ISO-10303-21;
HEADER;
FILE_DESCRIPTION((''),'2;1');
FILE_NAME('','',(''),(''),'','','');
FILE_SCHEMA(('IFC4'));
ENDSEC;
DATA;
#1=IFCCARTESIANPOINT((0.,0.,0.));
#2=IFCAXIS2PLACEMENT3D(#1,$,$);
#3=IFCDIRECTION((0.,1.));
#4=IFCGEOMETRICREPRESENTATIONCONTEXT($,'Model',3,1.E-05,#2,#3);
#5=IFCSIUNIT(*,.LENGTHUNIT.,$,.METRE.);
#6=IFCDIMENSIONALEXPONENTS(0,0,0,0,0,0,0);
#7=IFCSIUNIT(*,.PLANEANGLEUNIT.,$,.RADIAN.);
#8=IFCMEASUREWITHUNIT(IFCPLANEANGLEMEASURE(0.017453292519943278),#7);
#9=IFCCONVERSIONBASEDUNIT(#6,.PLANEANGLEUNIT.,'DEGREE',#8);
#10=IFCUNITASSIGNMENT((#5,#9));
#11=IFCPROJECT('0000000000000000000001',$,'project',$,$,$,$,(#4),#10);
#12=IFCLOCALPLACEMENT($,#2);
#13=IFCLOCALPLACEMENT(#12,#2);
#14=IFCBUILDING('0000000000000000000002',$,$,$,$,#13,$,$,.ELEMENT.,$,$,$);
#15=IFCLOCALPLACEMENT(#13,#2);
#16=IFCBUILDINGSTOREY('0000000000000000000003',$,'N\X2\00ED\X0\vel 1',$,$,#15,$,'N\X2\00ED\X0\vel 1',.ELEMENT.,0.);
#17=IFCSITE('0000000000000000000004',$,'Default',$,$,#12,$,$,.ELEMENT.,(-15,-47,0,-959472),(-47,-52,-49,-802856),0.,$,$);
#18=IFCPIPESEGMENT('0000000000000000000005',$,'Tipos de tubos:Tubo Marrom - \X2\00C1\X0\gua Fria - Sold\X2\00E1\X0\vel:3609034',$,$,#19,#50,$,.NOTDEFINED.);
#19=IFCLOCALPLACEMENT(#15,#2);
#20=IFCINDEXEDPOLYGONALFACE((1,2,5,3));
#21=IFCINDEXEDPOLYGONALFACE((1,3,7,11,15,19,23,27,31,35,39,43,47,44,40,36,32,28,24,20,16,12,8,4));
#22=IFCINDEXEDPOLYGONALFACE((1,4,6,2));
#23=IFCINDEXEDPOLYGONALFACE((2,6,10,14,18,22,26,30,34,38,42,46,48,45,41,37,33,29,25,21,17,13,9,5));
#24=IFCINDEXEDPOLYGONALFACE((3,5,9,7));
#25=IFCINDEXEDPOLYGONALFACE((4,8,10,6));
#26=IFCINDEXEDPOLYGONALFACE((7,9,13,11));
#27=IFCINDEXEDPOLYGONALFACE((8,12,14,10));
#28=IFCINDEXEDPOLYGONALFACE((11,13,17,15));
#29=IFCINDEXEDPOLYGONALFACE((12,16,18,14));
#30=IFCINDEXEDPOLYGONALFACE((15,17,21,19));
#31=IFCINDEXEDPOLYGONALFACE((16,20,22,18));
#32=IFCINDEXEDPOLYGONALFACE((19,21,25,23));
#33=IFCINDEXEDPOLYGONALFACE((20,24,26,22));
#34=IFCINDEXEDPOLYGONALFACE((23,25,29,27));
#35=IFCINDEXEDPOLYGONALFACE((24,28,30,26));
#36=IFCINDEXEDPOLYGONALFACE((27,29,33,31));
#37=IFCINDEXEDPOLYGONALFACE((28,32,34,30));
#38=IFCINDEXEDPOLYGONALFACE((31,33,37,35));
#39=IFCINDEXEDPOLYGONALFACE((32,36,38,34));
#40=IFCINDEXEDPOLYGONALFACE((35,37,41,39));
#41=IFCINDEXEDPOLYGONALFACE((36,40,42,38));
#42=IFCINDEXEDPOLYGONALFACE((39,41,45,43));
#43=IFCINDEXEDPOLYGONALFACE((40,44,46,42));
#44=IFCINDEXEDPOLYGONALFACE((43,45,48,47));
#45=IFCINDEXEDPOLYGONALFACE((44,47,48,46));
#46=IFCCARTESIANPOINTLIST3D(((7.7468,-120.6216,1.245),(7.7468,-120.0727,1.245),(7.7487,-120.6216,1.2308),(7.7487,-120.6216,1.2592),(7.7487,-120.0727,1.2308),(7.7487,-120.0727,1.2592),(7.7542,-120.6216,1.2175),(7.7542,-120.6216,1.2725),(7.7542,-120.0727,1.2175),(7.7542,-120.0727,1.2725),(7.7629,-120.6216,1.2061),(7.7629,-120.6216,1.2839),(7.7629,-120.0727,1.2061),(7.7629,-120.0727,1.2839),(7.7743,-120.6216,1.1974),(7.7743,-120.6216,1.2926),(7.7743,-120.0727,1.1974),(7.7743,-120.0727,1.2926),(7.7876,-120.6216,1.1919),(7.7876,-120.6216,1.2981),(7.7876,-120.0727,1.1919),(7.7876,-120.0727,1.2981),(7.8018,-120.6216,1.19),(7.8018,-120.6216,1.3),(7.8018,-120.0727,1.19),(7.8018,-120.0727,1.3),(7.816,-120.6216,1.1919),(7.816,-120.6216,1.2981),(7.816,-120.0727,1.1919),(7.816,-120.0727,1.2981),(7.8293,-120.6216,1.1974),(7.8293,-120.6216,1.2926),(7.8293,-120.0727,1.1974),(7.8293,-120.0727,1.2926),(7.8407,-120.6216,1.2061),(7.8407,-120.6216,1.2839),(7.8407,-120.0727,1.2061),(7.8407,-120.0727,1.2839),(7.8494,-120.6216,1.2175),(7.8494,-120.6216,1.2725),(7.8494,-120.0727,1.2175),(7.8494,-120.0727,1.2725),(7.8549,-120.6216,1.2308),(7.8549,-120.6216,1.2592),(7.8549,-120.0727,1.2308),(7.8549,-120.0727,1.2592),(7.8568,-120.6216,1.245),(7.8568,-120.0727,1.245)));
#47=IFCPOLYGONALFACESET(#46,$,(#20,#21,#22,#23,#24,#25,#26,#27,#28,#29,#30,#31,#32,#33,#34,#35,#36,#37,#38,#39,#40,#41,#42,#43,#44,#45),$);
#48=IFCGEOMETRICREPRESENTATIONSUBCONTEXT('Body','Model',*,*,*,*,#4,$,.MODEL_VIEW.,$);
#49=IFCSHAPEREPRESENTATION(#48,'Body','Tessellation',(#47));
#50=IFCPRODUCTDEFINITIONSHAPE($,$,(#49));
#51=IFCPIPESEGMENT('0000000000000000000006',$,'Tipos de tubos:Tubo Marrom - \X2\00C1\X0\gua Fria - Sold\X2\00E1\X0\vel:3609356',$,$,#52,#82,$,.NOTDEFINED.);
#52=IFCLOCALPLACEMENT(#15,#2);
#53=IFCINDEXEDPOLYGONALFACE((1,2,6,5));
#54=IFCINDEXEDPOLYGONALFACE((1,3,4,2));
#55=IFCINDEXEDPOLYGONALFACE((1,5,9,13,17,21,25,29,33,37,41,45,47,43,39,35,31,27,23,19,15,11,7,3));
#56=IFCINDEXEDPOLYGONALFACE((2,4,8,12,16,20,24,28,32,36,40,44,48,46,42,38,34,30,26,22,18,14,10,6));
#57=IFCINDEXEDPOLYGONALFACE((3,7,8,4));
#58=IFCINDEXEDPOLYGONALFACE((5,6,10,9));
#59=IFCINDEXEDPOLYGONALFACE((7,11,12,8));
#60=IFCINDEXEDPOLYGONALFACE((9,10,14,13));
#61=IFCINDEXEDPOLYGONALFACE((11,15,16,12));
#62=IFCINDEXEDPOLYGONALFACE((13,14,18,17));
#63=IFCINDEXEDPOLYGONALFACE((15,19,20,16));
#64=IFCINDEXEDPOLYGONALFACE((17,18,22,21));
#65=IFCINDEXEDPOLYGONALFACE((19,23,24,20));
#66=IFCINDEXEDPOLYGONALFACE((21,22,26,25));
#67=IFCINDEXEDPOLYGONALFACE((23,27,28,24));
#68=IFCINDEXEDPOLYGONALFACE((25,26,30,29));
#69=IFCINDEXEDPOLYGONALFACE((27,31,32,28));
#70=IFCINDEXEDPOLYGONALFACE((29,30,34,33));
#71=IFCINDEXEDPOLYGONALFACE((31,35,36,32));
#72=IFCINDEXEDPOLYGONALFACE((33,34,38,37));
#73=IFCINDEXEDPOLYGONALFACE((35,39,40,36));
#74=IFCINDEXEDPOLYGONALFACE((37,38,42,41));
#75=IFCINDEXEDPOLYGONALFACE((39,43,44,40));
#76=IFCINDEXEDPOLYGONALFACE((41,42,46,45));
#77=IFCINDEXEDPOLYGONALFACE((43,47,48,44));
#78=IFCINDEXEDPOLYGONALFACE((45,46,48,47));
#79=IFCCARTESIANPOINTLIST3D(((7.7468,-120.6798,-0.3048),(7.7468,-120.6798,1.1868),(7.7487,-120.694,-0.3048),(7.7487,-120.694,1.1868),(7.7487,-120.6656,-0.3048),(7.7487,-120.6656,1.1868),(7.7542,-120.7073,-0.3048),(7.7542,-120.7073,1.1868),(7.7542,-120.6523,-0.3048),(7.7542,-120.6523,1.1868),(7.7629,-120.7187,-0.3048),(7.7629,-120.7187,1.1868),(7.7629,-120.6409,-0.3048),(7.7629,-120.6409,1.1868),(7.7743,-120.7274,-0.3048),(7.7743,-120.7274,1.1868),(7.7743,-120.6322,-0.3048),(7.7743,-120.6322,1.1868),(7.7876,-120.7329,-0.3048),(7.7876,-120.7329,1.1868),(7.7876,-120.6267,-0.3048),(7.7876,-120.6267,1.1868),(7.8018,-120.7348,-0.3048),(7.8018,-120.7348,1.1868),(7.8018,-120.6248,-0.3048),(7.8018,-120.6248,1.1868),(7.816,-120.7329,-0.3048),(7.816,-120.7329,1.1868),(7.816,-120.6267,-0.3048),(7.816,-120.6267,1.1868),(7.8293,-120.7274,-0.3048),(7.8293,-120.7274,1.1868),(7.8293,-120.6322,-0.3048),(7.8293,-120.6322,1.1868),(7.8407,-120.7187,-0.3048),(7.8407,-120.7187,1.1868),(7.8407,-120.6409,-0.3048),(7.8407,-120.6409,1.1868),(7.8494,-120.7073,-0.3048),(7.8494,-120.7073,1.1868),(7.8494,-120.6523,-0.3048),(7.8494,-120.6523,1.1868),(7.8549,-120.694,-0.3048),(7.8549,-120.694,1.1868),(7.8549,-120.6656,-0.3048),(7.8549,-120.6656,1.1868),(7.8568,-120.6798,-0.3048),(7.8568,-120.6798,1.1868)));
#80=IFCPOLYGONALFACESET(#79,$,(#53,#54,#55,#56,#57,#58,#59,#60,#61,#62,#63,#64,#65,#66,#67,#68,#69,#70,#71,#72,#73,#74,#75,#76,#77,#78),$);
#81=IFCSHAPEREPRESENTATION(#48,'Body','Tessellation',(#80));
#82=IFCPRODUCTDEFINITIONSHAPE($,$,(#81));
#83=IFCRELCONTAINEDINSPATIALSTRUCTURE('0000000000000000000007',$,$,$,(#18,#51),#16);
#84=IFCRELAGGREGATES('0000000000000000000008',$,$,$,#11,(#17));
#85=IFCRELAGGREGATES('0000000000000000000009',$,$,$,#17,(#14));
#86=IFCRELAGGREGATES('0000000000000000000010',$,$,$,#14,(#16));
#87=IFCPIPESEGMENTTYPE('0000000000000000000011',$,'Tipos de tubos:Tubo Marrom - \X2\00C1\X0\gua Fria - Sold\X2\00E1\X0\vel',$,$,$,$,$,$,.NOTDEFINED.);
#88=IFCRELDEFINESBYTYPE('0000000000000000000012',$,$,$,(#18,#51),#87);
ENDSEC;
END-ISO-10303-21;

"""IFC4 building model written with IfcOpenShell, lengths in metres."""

from ifc_helpers import new_model, entity, si_unit, converted_unit, direction, frame, origin, place, context, subcontext, project, spatial, arc, indexed_curve, outline, extrude, type_object, element, save


model = new_model("IFC4")

# Units and contexts
model_context = context("Model", 3, precision=1e-05, world=origin(), true_north=direction((0.0, 1.0)))
body_context = subcontext(model_context, "Body", "Model", "MODEL_VIEW")
ifc_project = project(units=[si_unit("LENGTHUNIT", "METRE"), converted_unit("PLANEANGLEUNIT", "DEGREE", entity("IfcPlaneAngleMeasure", 0.017453292519943278), si_unit("PLANEANGLEUNIT", "RADIAN"), dimensions=[0, 0, 0, 0, 0, 0, 0])], contexts=[model_context])

# Site, building, storey
site_placement = place(None, origin())
site = spatial("IfcSite", under=ifc_project, at=site_placement, Name="Default", CompositionType="ELEMENT", RefLatitude=(-15, -47, 0, -959472), RefLongitude=(-47, -52, -49, -802856), RefElevation=0.0)
building_placement = place(site_placement, origin())
building = spatial("IfcBuilding", under=site, at=building_placement, CompositionType="ELEMENT")
storey_placement = place(building_placement, origin())
storey = spatial("IfcBuildingStorey", under=building, at=storey_placement, Name="Nível 1", LongName="Nível 1", CompositionType="ELEMENT", Elevation=0.0)

# Pipe segments
pipe_segment_type = type_object("IfcPipeSegmentType", Name="Tipos de tubos:Tubo Marrom - Água Fria - Soldável", PredefinedType="NOTDEFINED")
pipe_segment_1_placement = place(storey_placement, frame((7.7452, -120.6216, 1.1884)))
element("IfcPipeSegment", 1, at=pipe_segment_1_placement, inside=storey, type_object=pipe_segment_type, Name="Tipos de tubos:Tubo Marrom - Água Fria - Soldável:3609034", PredefinedType="NOTDEFINED", context=body_context, shape_type="SweptSolid", body=[
    extrude(outline(indexed_curve([(0.055, 0.0), (0.0389, 0.0389), (0.0, 0.055), (-0.0389, 0.0389), (-0.055, 0.0), (-0.0389, -0.0389), (0.0, -0.055), (0.0389, -0.0389)], segments=[arc(1, 2, 3), arc(3, 4, 5), arc(5, 6, 7), arc(7, 8, 1)], self_intersect=False)), frame((0.0566, 0.0, 0.0566), z_axis=(0.0, 1.0, 0.0), x_axis=(1.0, 0.0, 0.0)), (0.0, 0.0, 1.0), 0.5489),
])
pipe_segment_2_placement = place(storey_placement, frame((7.7452, -120.7364, -0.3048)))
element("IfcPipeSegment", 2, at=pipe_segment_2_placement, inside=storey, type_object=pipe_segment_type, Name="Tipos de tubos:Tubo Marrom - Água Fria - Soldável:3609356", PredefinedType="NOTDEFINED", context=body_context, shape_type="SweptSolid", body=[
    extrude(outline(indexed_curve([(0.0, 0.055), (-0.0389, 0.0389), (-0.055, 0.0), (-0.0389, -0.0389), (0.0, -0.055), (0.0389, -0.0389), (0.055, 0.0), (0.0389, 0.0389)], segments=[arc(1, 2, 3), arc(3, 4, 5), arc(5, 6, 7), arc(7, 8, 1)], self_intersect=False)), frame((0.0566, 0.0566, 0.0)), (0.0, 0.0, 1.0), 1.4916),
])

save(model, "model.ifc")
